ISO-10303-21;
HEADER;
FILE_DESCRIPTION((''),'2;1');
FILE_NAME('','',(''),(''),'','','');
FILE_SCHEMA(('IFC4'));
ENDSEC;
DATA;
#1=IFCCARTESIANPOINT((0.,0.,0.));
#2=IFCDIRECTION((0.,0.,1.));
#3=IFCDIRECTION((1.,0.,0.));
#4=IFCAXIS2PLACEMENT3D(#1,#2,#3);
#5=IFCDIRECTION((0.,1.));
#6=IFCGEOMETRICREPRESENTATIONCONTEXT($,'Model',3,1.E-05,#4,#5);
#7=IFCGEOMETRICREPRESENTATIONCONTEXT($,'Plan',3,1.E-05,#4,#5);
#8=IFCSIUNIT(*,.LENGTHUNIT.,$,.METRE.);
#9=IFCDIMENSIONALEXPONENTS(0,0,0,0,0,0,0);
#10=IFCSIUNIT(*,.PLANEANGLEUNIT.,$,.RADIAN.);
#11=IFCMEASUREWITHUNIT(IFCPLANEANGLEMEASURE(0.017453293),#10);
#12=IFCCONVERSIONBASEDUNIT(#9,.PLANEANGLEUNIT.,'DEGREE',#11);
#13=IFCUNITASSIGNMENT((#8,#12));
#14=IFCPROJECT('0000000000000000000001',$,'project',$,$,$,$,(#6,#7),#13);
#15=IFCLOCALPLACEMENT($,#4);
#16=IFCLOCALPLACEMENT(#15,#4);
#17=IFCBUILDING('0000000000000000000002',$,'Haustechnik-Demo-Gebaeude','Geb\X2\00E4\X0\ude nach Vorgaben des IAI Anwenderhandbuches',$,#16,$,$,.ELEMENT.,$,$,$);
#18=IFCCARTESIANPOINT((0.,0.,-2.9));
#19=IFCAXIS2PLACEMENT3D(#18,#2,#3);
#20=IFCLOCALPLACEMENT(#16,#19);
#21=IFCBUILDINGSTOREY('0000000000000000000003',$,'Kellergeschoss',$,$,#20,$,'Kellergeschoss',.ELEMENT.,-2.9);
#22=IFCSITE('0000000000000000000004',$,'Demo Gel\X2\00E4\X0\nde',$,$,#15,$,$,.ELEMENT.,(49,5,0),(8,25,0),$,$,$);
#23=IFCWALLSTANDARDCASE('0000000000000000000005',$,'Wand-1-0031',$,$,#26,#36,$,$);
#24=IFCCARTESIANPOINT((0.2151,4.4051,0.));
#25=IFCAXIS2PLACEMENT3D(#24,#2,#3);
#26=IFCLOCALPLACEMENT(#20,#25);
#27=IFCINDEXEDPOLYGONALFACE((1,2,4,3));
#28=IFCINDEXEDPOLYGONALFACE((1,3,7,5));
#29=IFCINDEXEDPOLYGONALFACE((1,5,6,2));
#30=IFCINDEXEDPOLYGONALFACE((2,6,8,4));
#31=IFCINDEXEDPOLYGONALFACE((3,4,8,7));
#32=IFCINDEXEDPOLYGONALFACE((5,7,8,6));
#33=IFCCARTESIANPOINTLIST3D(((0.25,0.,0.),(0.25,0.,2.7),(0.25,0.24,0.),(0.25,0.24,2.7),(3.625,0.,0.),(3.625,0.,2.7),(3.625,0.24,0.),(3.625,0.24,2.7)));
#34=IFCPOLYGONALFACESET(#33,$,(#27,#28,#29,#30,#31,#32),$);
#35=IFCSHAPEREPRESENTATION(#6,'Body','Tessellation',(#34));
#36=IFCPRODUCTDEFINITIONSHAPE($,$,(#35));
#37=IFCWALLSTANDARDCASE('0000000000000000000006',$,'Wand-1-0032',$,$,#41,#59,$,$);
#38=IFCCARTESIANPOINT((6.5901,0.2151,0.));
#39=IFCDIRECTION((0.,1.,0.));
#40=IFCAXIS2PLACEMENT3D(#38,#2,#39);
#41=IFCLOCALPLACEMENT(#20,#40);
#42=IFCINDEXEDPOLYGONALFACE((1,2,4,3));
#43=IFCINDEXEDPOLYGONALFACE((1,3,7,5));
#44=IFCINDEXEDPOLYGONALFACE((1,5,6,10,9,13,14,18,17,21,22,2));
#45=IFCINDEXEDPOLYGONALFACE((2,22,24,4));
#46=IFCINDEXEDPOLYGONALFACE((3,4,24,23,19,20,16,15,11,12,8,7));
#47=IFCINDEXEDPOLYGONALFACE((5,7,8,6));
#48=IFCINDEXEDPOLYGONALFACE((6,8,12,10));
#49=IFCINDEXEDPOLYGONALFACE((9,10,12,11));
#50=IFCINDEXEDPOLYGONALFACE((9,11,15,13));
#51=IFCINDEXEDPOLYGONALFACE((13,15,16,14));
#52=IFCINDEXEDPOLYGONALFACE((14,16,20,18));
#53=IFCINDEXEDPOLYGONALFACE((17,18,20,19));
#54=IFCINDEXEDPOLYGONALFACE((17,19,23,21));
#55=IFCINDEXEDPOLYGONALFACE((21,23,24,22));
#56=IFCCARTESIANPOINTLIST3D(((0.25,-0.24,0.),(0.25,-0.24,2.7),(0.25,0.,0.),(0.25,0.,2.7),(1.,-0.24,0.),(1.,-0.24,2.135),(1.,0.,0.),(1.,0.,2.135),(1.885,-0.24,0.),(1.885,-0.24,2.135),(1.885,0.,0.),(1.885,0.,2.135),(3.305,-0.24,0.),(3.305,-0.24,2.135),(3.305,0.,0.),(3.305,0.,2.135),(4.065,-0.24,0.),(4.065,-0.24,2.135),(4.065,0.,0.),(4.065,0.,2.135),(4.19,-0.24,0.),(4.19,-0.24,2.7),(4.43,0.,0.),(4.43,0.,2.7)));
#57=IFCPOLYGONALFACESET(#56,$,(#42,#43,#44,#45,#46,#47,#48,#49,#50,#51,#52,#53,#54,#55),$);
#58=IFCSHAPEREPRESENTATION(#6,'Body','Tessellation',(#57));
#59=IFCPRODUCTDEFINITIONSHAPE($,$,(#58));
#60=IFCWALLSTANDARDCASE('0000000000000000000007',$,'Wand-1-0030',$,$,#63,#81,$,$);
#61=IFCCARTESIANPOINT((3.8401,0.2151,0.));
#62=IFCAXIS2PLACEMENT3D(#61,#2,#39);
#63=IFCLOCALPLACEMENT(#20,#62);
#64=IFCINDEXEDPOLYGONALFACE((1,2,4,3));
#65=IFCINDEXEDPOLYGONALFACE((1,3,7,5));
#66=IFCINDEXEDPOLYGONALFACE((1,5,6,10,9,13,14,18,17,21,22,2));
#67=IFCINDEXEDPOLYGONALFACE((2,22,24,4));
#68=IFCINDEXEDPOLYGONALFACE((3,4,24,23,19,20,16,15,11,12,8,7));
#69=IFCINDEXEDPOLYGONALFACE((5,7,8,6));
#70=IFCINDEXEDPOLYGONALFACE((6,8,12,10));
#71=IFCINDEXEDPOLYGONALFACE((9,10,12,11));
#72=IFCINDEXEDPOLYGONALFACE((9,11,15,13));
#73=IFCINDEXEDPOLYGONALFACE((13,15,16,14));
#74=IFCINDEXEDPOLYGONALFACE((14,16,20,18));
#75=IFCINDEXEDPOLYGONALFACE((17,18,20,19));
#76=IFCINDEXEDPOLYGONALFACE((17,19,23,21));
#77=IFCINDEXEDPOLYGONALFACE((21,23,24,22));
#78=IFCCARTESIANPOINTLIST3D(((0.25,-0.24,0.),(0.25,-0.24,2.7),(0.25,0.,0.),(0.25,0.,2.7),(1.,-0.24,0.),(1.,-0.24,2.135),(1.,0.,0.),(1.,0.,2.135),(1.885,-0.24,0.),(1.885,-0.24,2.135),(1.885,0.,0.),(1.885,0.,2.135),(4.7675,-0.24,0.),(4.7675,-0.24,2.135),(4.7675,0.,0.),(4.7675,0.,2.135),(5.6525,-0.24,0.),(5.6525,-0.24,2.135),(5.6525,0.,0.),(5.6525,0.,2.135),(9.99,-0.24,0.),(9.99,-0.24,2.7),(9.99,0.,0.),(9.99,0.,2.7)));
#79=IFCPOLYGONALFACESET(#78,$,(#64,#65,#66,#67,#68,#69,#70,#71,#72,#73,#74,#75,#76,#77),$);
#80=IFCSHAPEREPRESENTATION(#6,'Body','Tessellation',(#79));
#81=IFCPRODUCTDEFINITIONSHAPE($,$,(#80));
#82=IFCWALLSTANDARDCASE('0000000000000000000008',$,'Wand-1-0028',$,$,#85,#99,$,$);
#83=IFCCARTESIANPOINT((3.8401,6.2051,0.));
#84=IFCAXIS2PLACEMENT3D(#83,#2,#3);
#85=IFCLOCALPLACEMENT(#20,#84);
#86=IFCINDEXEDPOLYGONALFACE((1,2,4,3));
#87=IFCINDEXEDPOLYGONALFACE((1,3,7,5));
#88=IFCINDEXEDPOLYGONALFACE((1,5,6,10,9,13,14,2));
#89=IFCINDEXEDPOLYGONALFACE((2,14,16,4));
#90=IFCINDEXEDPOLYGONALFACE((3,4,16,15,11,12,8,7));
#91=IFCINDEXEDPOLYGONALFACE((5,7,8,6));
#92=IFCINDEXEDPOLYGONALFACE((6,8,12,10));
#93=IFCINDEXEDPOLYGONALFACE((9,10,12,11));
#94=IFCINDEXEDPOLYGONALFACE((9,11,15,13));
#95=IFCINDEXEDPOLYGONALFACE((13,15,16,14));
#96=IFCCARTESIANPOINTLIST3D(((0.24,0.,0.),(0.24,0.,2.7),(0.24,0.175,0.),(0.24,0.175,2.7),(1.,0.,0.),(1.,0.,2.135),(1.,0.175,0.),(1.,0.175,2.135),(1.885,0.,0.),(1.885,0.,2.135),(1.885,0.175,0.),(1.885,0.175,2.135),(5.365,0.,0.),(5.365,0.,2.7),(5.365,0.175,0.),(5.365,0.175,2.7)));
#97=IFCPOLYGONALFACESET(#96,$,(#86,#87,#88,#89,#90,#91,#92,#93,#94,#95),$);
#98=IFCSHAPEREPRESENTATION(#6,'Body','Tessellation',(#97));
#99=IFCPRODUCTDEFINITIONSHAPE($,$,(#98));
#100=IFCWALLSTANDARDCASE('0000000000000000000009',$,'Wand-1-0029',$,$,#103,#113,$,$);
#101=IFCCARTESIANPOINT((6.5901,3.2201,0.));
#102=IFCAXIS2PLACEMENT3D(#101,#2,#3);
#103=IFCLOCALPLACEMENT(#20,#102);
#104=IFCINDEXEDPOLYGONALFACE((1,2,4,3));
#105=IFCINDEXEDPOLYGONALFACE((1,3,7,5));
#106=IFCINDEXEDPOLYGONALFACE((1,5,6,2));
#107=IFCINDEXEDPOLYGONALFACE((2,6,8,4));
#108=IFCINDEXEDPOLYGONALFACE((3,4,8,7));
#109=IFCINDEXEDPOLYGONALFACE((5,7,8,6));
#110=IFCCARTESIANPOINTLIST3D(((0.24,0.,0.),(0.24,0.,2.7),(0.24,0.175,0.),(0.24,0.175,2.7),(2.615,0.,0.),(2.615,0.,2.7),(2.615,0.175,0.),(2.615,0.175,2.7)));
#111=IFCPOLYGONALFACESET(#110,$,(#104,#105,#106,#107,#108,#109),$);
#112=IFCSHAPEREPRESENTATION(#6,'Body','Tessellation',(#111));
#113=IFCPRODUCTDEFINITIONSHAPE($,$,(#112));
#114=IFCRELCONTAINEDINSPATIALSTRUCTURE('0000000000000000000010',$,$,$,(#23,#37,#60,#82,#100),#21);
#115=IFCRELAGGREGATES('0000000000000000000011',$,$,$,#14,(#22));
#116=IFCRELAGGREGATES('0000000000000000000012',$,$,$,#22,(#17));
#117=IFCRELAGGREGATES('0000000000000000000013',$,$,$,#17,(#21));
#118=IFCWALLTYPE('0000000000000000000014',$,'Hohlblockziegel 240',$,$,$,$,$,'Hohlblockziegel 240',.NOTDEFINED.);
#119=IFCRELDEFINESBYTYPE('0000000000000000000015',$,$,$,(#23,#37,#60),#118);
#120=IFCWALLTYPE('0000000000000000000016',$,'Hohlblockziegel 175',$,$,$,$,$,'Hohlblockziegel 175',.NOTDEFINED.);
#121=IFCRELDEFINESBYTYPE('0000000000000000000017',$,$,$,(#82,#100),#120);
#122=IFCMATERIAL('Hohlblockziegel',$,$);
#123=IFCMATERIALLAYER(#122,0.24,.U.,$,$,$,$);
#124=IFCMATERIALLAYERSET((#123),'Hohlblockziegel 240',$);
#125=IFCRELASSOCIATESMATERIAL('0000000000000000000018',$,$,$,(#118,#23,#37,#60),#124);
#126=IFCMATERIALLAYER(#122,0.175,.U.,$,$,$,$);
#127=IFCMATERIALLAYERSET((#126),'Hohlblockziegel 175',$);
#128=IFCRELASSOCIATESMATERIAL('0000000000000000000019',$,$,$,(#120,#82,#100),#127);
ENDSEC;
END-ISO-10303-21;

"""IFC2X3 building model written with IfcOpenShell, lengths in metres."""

from ifc_helpers import new_model, entity, si_unit, converted_unit, direction, frame, frame_2d, origin_with_axes, place, context, project, spatial, polyline, rectangle, outline, extrude, material, layer, layer_set, layer_usage, type_object, element, save


model = new_model("IFC2X3")

# Units and contexts
model_context = context("Model", 3, precision=1e-05, world=origin_with_axes(), true_north=direction((0.0, 1.0)))
plan_context = context("Plan", 3, precision=1e-05, world=origin_with_axes(), true_north=direction((0.0, 1.0)))
ifc_project = project(units=[si_unit("LENGTHUNIT", "METRE"), converted_unit("PLANEANGLEUNIT", "DEGREE", entity("IfcPlaneAngleMeasure", 0.017453293), si_unit("PLANEANGLEUNIT", "RADIAN"), dimensions=[0, 0, 0, 0, 0, 0, 0])], contexts=[model_context, plan_context])

# Site, building, storey
site_placement = place(None, origin_with_axes())
site = spatial("IfcSite", under=ifc_project, at=site_placement, Name="Demo Gelände", CompositionType="ELEMENT", RefLatitude=(49, 5, 0), RefLongitude=(8, 25, 0))
building_placement = place(site_placement, origin_with_axes())
building = spatial("IfcBuilding", under=site, at=building_placement, Name="Haustechnik-Demo-Gebaeude", Description="Gebäude nach Vorgaben des IAI Anwenderhandbuches", CompositionType="ELEMENT")
storey_placement = place(building_placement, frame((0.0, 0.0, -2.9), z_axis=(0.0, 0.0, 1.0), x_axis=(1.0, 0.0, 0.0)))
storey = spatial("IfcBuildingStorey", under=building, at=storey_placement, Name="Kellergeschoss", LongName="Kellergeschoss", CompositionType="ELEMENT", Elevation=-2.9)

# Wall
ifc_material_1 = material(Name="Hohlblockziegel")
ifc_layer_1 = layer(ifc_material_1, 0.24, ventilated="UNKNOWN")
ifc_layer_set_1 = layer_set([ifc_layer_1], Name="Hohlblockziegel 240")
ifc_layer_usage_1 = layer_usage(ifc_layer_set_1, "AXIS2", "POSITIVE", 0.0)
wall_type_1 = type_object("IfcWallType", Name="Hohlblockziegel 240", ElementType="Hohlblockziegel 240", PredefinedType="NOTDEFINED", material=ifc_layer_set_1)
wall_1_placement = place(storey_placement, frame((0.2151, 4.4051, 0.0), z_axis=(0.0, 0.0, 1.0), x_axis=(1.0, 0.0, 0.0)))
element("IfcWallStandardCase", 1, at=wall_1_placement, inside=storey, type_object=wall_type_1, material=ifc_layer_usage_1, Name="Wand-1-0031", context=model_context, shape_type="SweptSolid", body=[
    extrude(outline(polyline([(0.25, 0.0), (3.625, 0.0), (3.625, 0.24), (0.25, 0.24), (0.25, 0.0)])), origin_with_axes(), (0.0, 0.0, 1.0), 2.7),
])

# Wall, openings
ifc_layer_usage_2 = layer_usage(ifc_layer_set_1, "AXIS2", "NEGATIVE", 0.0)
wall_2_placement = place(storey_placement, frame((6.5901, 0.2151, 0.0), z_axis=(0.0, 0.0, 1.0), x_axis=(0.0, 1.0, 0.0)))
wall_2 = element("IfcWallStandardCase", 2, at=wall_2_placement, inside=storey, type_object=wall_type_1, material=ifc_layer_usage_2, Name="Wand-1-0032", context=model_context, shape_type="SweptSolid", body=[
    extrude(outline(polyline([(0.25, -0.24), (4.19, -0.24), (4.43, 0.0), (0.25, 0.0), (0.25, -0.24)])), origin_with_axes(), (0.0, 0.0, 1.0), 2.7),
])
opening_1_placement = place(wall_2_placement, frame((3.685, -0.24, 0.0), z_axis=(0.0, 0.0, 1.0), x_axis=(1.0, 0.0, 0.0)))
element("IfcOpeningElement", 3, at=opening_1_placement, cuts=wall_2, ObjectType="Opening", context=model_context, shape_type="SweptSolid", body=[
    extrude(rectangle(XDim=0.76, YDim=2.135, at=frame_2d((0.0, 1.0675), x_axis=(-1.0, 0.0))), frame((0.0, 0.0, 0.0), z_axis=(0.0, 1.0, 0.0), x_axis=(-1.0, 0.0, 0.0)), (0.0, 0.0, 1.0), 0.24),
])
opening_2_placement = place(wall_2_placement, frame((1.4425, -0.24, 0.0), z_axis=(0.0, 0.0, 1.0), x_axis=(1.0, 0.0, 0.0)))
element("IfcOpeningElement", 4, at=opening_2_placement, cuts=wall_2, ObjectType="Opening", context=model_context, shape_type="SweptSolid", body=[
    extrude(rectangle(XDim=0.885, YDim=2.135, at=frame_2d((0.0, 1.0675), x_axis=(-1.0, 0.0))), frame((0.0, 0.0, 0.0), z_axis=(0.0, 1.0, 0.0), x_axis=(-1.0, 0.0, 0.0)), (0.0, 0.0, 1.0), 0.24),
])

# Wall, openings
ifc_layer_usage_3 = layer_usage(ifc_layer_set_1, "AXIS2", "NEGATIVE", 0.0)
wall_3_placement = place(storey_placement, frame((3.8401, 0.2151, 0.0), z_axis=(0.0, 0.0, 1.0), x_axis=(0.0, 1.0, 0.0)))
wall_3 = element("IfcWallStandardCase", 5, at=wall_3_placement, inside=storey, type_object=wall_type_1, material=ifc_layer_usage_3, Name="Wand-1-0030", context=model_context, shape_type="SweptSolid", body=[
    extrude(outline(polyline([(0.25, -0.24), (9.99, -0.24), (9.99, 0.0), (0.25, 0.0), (0.25, -0.24)])), origin_with_axes(), (0.0, 0.0, 1.0), 2.7),
])
opening_3_placement = place(wall_3_placement, frame((5.21, -0.24, 0.0), z_axis=(0.0, 0.0, 1.0), x_axis=(1.0, 0.0, 0.0)))
element("IfcOpeningElement", 6, at=opening_3_placement, cuts=wall_3, ObjectType="Opening", context=model_context, shape_type="SweptSolid", body=[
    extrude(rectangle(XDim=0.885, YDim=2.135, at=frame_2d((0.0, 1.0675), x_axis=(-1.0, 0.0))), frame((0.0, 0.0, 0.0), z_axis=(0.0, 1.0, 0.0), x_axis=(-1.0, 0.0, 0.0)), (0.0, 0.0, 1.0), 0.24),
])
opening_4_placement = place(wall_3_placement, frame((1.4425, -0.24, 0.0), z_axis=(0.0, 0.0, 1.0), x_axis=(1.0, 0.0, 0.0)))
element("IfcOpeningElement", 7, at=opening_4_placement, cuts=wall_3, ObjectType="Opening", context=model_context, shape_type="SweptSolid", body=[
    extrude(rectangle(XDim=0.885, YDim=2.135, at=frame_2d((0.0, 1.0675), x_axis=(-1.0, 0.0))), frame((0.0, 0.0, 0.0), z_axis=(0.0, 1.0, 0.0), x_axis=(-1.0, 0.0, 0.0)), (0.0, 0.0, 1.0), 0.24),
])

# Wall, opening
ifc_layer_2 = layer(ifc_material_1, 0.175, ventilated="UNKNOWN")
ifc_layer_set_2 = layer_set([ifc_layer_2], Name="Hohlblockziegel 175")
ifc_layer_usage_4 = layer_usage(ifc_layer_set_2, "AXIS2", "POSITIVE", 0.0)
wall_type_2 = type_object("IfcWallType", Name="Hohlblockziegel 175", ElementType="Hohlblockziegel 175", PredefinedType="NOTDEFINED", material=ifc_layer_set_2)
wall_4_placement = place(storey_placement, frame((3.8401, 6.2051, 0.0), z_axis=(0.0, 0.0, 1.0), x_axis=(1.0, 0.0, 0.0)))
wall_4 = element("IfcWallStandardCase", 8, at=wall_4_placement, inside=storey, type_object=wall_type_2, material=ifc_layer_usage_4, Name="Wand-1-0028", context=model_context, shape_type="SweptSolid", body=[
    extrude(outline(polyline([(0.24, 0.0), (5.365, 0.0), (5.365, 0.175), (0.24, 0.175), (0.24, 0.0)])), origin_with_axes(), (0.0, 0.0, 1.0), 2.7),
])
opening_5_placement = place(wall_4_placement, frame((1.4425, 0.0, 0.0), z_axis=(0.0, 0.0, 1.0), x_axis=(1.0, 0.0, 0.0)))
element("IfcOpeningElement", 9, at=opening_5_placement, cuts=wall_4, ObjectType="Opening", context=model_context, shape_type="SweptSolid", body=[
    extrude(rectangle(XDim=0.885, YDim=2.135, at=frame_2d((0.0, 1.0675), x_axis=(-1.0, 0.0))), frame((0.0, 0.0, 0.0), z_axis=(0.0, 1.0, 0.0), x_axis=(-1.0, 0.0, 0.0)), (0.0, 0.0, 1.0), 0.175),
])

# Wall
ifc_layer_usage_5 = layer_usage(ifc_layer_set_2, "AXIS2", "POSITIVE", 0.0)
wall_5_placement = place(storey_placement, frame((6.5901, 3.2201, 0.0), z_axis=(0.0, 0.0, 1.0), x_axis=(1.0, 0.0, 0.0)))
element("IfcWallStandardCase", 10, at=wall_5_placement, inside=storey, type_object=wall_type_2, material=ifc_layer_usage_5, Name="Wand-1-0029", context=model_context, shape_type="SweptSolid", body=[
    extrude(outline(polyline([(0.24, 0.0), (2.615, 0.0), (2.615, 0.175), (0.24, 0.175), (0.24, 0.0)])), origin_with_axes(), (0.0, 0.0, 1.0), 2.7),
])

save(model, "model.ifc")
